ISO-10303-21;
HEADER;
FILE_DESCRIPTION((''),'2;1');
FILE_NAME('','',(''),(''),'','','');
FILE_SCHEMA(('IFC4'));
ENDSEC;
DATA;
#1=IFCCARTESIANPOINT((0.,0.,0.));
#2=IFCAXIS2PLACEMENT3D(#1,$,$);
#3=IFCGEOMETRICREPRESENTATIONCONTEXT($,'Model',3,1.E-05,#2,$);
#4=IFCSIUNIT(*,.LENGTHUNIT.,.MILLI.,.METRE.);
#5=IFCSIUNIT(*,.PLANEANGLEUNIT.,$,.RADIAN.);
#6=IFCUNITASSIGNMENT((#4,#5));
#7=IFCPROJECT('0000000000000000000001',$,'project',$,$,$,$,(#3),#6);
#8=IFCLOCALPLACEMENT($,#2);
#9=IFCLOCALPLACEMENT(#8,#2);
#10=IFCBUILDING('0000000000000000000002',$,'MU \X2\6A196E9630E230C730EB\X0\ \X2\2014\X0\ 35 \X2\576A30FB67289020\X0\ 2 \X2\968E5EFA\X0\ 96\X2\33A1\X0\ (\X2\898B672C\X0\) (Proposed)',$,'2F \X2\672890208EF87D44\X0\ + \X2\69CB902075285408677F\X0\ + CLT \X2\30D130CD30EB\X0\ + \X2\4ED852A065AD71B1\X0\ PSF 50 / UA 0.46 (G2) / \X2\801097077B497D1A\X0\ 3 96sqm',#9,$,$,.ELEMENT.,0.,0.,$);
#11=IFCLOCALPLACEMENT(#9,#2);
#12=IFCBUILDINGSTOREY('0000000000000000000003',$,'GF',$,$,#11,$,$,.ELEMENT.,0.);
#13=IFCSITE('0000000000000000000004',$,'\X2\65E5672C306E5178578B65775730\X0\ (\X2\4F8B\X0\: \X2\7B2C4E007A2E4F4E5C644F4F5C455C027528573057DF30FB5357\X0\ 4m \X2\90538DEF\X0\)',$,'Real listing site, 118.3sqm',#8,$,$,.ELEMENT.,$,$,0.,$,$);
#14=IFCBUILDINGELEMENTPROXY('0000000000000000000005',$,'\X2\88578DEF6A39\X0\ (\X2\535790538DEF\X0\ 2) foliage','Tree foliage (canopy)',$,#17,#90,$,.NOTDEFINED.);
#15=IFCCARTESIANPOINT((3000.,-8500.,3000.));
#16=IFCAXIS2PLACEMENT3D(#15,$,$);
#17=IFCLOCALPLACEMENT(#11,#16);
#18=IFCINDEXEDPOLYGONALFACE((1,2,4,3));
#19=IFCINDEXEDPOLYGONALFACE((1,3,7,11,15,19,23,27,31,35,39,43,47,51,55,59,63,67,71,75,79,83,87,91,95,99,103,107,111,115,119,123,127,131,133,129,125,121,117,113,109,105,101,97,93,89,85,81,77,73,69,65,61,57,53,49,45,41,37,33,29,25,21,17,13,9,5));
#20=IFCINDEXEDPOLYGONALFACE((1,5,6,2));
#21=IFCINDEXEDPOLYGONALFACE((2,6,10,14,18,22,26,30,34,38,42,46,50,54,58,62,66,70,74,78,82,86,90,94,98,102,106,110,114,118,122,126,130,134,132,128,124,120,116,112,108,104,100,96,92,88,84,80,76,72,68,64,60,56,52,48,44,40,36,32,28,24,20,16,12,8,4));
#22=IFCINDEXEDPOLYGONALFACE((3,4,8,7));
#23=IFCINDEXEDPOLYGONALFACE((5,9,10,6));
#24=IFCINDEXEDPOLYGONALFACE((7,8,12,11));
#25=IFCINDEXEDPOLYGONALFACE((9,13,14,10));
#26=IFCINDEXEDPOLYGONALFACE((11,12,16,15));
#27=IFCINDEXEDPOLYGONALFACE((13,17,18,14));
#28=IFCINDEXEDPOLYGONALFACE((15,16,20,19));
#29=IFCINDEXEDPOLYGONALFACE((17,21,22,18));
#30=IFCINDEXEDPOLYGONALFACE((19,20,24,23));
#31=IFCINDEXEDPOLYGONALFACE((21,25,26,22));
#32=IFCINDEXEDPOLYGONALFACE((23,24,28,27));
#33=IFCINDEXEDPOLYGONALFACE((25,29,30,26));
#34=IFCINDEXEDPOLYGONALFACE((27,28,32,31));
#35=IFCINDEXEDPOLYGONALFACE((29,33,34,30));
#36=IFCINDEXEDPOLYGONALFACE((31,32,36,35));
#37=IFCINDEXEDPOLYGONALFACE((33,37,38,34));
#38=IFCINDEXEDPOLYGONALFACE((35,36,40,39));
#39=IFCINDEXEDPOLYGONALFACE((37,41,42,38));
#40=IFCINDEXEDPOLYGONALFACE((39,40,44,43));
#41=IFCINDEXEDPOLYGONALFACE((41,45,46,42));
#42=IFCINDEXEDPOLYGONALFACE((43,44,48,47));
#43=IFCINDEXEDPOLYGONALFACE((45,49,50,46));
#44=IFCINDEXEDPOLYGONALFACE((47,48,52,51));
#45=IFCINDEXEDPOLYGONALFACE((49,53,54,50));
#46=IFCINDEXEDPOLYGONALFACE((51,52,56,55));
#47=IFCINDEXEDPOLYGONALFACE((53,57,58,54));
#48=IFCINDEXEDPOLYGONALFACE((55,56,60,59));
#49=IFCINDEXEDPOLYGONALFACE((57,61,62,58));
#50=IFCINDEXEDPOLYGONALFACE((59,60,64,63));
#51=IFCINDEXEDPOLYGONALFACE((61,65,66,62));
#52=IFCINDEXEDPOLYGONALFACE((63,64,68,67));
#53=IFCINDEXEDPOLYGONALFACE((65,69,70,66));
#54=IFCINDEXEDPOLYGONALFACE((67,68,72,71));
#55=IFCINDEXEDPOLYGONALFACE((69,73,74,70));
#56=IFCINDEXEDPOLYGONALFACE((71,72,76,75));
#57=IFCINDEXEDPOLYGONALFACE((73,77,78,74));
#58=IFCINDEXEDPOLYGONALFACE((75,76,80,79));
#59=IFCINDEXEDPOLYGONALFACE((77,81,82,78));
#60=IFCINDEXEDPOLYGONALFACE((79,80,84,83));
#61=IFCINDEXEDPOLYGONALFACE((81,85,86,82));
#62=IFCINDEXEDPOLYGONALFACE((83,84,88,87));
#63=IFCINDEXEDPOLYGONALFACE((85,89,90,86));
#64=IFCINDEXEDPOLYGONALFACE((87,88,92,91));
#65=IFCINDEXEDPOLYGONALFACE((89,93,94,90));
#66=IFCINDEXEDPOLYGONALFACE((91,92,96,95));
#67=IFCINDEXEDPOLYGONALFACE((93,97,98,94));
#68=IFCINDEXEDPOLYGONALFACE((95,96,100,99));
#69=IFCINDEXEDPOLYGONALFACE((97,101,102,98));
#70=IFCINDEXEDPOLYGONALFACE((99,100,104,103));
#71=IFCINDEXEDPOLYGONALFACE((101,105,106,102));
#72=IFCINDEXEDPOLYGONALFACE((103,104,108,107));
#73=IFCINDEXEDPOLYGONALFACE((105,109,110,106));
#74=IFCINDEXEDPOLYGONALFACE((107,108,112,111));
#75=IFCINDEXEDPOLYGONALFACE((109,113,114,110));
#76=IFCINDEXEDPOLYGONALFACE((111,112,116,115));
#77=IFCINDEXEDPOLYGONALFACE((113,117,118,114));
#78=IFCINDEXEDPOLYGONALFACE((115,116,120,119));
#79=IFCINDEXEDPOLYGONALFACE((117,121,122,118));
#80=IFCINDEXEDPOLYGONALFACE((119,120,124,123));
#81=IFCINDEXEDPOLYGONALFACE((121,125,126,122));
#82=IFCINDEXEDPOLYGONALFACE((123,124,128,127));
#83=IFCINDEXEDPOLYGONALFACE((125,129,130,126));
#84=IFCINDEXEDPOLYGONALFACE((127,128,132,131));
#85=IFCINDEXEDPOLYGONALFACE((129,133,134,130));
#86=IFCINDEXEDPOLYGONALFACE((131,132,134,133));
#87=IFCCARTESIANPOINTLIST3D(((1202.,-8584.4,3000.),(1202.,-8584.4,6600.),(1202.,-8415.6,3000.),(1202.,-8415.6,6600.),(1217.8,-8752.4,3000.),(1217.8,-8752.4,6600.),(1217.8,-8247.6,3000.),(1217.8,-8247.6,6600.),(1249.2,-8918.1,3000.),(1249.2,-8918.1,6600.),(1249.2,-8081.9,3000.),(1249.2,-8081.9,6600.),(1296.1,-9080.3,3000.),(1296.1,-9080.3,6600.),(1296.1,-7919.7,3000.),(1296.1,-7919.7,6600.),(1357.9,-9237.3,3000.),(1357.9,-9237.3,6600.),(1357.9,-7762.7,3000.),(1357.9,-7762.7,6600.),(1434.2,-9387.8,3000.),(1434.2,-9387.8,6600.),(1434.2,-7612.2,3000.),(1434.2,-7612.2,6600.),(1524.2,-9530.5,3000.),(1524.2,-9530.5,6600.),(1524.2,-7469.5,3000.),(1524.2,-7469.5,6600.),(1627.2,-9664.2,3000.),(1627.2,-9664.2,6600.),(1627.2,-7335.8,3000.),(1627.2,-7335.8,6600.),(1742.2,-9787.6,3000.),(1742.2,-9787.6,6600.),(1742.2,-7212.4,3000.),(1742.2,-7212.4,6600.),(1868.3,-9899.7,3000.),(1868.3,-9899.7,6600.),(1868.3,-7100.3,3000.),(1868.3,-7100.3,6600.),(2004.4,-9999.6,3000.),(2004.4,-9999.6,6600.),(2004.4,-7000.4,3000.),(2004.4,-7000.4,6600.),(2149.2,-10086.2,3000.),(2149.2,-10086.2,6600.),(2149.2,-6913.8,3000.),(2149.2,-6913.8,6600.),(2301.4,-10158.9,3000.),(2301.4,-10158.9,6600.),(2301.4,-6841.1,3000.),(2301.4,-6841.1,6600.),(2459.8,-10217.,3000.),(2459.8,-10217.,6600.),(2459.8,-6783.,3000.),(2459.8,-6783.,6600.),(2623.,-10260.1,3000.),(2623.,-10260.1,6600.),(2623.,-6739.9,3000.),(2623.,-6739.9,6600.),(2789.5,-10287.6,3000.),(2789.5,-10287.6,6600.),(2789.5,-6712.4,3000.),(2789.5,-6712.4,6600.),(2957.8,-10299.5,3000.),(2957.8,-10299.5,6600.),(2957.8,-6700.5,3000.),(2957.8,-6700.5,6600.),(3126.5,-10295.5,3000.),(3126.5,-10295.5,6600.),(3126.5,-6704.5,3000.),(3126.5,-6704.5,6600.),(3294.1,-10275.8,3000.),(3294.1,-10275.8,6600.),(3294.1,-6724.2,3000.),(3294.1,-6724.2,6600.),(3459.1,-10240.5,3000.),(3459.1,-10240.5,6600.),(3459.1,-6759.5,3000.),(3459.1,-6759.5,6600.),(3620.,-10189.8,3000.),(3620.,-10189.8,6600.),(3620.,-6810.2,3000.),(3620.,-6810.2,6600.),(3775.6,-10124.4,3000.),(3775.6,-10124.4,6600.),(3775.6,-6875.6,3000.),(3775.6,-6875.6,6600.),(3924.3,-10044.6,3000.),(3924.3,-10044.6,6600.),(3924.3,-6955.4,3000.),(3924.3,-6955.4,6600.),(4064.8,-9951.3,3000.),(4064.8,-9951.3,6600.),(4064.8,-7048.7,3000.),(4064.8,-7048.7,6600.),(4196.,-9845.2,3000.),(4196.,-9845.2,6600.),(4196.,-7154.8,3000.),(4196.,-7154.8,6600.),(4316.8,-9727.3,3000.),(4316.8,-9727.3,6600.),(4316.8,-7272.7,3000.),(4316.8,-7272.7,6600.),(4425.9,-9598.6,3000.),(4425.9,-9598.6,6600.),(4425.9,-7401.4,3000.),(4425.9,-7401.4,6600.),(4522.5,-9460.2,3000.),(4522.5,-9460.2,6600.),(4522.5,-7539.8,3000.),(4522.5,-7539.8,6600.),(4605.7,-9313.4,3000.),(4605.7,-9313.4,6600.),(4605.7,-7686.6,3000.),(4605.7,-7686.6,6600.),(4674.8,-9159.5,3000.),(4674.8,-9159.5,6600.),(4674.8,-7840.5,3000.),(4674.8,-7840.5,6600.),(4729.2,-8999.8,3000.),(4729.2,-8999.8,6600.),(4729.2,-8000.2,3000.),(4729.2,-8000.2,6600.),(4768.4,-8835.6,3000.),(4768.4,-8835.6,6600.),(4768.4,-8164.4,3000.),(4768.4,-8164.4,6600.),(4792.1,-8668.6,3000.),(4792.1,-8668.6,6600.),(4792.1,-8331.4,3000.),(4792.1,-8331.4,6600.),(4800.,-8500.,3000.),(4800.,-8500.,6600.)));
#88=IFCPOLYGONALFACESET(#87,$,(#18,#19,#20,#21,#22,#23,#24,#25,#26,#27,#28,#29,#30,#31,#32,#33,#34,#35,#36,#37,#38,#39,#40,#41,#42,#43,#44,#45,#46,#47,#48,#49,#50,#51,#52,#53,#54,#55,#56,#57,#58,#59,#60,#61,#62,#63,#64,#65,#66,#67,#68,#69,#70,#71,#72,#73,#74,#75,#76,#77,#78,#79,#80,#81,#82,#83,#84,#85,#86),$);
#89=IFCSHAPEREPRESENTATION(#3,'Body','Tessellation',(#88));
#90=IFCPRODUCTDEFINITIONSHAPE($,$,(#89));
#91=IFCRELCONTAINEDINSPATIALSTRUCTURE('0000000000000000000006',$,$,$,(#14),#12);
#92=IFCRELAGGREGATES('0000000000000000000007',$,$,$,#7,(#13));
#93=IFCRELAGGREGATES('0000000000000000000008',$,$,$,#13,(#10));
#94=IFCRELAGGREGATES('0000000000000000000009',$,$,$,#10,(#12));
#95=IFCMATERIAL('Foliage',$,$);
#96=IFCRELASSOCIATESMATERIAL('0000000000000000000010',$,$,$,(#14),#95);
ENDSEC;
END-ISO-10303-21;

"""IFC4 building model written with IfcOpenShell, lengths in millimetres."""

from ifc_helpers import new_model, si_unit, frame, origin, origin_2d, place, context, project, spatial, circle, extrude, material, element, save


model = new_model("IFC4")

# Units and contexts
model_context = context("Model", 3, precision=1e-05, world=origin())
ifc_project = project(units=[si_unit("LENGTHUNIT", "METRE", prefix="MILLI"), si_unit("PLANEANGLEUNIT", "RADIAN")], contexts=[model_context])

# Site, building, storey
site_placement = place(None, origin())
site = spatial("IfcSite", under=ifc_project, at=site_placement, Name="日本の典型敷地 (例: 第一種低層住居専用地域・南 4m 道路)", ObjectType="Real listing site, 118.3sqm", CompositionType="ELEMENT", RefElevation=0.0)
building_placement = place(site_placement, origin())
building = spatial("IfcBuilding", under=site, at=building_placement, Name="MU 標準モデル — 35 坪・木造 2 階建 96㎡ (見本) (Proposed)", ObjectType="2F 木造軸組 + 構造用合板 + CLT パネル + 付加断熱 PSF 50 / UA 0.46 (G2) / 耐震等級 3 96sqm", CompositionType="ELEMENT", ElevationOfRefHeight=0.0, ElevationOfTerrain=0.0)
storey_placement = place(building_placement, origin())
storey = spatial("IfcBuildingStorey", under=building, at=storey_placement, Name="GF", CompositionType="ELEMENT", Elevation=0.0)

# Building element proxy
ifc_material_1 = material(Name="Foliage")
proxy_1_placement = place(storey_placement, frame((3000.0, -8500.0, 3000.0)))
element("IfcBuildingElementProxy", 1, at=proxy_1_placement, inside=storey, material=ifc_material_1, Name="街路樹 (南道路 2) foliage", Description="Tree foliage (canopy)", PredefinedType="NOTDEFINED", context=model_context, shape_type="SweptSolid", body=[
    extrude(circle(Radius=1800.0, at=origin_2d()), frame((3000.0, -8500.0, 3000.0)), (0.0, 0.0, 1.0), 3600.0),
])

save(model, "model.ifc")
